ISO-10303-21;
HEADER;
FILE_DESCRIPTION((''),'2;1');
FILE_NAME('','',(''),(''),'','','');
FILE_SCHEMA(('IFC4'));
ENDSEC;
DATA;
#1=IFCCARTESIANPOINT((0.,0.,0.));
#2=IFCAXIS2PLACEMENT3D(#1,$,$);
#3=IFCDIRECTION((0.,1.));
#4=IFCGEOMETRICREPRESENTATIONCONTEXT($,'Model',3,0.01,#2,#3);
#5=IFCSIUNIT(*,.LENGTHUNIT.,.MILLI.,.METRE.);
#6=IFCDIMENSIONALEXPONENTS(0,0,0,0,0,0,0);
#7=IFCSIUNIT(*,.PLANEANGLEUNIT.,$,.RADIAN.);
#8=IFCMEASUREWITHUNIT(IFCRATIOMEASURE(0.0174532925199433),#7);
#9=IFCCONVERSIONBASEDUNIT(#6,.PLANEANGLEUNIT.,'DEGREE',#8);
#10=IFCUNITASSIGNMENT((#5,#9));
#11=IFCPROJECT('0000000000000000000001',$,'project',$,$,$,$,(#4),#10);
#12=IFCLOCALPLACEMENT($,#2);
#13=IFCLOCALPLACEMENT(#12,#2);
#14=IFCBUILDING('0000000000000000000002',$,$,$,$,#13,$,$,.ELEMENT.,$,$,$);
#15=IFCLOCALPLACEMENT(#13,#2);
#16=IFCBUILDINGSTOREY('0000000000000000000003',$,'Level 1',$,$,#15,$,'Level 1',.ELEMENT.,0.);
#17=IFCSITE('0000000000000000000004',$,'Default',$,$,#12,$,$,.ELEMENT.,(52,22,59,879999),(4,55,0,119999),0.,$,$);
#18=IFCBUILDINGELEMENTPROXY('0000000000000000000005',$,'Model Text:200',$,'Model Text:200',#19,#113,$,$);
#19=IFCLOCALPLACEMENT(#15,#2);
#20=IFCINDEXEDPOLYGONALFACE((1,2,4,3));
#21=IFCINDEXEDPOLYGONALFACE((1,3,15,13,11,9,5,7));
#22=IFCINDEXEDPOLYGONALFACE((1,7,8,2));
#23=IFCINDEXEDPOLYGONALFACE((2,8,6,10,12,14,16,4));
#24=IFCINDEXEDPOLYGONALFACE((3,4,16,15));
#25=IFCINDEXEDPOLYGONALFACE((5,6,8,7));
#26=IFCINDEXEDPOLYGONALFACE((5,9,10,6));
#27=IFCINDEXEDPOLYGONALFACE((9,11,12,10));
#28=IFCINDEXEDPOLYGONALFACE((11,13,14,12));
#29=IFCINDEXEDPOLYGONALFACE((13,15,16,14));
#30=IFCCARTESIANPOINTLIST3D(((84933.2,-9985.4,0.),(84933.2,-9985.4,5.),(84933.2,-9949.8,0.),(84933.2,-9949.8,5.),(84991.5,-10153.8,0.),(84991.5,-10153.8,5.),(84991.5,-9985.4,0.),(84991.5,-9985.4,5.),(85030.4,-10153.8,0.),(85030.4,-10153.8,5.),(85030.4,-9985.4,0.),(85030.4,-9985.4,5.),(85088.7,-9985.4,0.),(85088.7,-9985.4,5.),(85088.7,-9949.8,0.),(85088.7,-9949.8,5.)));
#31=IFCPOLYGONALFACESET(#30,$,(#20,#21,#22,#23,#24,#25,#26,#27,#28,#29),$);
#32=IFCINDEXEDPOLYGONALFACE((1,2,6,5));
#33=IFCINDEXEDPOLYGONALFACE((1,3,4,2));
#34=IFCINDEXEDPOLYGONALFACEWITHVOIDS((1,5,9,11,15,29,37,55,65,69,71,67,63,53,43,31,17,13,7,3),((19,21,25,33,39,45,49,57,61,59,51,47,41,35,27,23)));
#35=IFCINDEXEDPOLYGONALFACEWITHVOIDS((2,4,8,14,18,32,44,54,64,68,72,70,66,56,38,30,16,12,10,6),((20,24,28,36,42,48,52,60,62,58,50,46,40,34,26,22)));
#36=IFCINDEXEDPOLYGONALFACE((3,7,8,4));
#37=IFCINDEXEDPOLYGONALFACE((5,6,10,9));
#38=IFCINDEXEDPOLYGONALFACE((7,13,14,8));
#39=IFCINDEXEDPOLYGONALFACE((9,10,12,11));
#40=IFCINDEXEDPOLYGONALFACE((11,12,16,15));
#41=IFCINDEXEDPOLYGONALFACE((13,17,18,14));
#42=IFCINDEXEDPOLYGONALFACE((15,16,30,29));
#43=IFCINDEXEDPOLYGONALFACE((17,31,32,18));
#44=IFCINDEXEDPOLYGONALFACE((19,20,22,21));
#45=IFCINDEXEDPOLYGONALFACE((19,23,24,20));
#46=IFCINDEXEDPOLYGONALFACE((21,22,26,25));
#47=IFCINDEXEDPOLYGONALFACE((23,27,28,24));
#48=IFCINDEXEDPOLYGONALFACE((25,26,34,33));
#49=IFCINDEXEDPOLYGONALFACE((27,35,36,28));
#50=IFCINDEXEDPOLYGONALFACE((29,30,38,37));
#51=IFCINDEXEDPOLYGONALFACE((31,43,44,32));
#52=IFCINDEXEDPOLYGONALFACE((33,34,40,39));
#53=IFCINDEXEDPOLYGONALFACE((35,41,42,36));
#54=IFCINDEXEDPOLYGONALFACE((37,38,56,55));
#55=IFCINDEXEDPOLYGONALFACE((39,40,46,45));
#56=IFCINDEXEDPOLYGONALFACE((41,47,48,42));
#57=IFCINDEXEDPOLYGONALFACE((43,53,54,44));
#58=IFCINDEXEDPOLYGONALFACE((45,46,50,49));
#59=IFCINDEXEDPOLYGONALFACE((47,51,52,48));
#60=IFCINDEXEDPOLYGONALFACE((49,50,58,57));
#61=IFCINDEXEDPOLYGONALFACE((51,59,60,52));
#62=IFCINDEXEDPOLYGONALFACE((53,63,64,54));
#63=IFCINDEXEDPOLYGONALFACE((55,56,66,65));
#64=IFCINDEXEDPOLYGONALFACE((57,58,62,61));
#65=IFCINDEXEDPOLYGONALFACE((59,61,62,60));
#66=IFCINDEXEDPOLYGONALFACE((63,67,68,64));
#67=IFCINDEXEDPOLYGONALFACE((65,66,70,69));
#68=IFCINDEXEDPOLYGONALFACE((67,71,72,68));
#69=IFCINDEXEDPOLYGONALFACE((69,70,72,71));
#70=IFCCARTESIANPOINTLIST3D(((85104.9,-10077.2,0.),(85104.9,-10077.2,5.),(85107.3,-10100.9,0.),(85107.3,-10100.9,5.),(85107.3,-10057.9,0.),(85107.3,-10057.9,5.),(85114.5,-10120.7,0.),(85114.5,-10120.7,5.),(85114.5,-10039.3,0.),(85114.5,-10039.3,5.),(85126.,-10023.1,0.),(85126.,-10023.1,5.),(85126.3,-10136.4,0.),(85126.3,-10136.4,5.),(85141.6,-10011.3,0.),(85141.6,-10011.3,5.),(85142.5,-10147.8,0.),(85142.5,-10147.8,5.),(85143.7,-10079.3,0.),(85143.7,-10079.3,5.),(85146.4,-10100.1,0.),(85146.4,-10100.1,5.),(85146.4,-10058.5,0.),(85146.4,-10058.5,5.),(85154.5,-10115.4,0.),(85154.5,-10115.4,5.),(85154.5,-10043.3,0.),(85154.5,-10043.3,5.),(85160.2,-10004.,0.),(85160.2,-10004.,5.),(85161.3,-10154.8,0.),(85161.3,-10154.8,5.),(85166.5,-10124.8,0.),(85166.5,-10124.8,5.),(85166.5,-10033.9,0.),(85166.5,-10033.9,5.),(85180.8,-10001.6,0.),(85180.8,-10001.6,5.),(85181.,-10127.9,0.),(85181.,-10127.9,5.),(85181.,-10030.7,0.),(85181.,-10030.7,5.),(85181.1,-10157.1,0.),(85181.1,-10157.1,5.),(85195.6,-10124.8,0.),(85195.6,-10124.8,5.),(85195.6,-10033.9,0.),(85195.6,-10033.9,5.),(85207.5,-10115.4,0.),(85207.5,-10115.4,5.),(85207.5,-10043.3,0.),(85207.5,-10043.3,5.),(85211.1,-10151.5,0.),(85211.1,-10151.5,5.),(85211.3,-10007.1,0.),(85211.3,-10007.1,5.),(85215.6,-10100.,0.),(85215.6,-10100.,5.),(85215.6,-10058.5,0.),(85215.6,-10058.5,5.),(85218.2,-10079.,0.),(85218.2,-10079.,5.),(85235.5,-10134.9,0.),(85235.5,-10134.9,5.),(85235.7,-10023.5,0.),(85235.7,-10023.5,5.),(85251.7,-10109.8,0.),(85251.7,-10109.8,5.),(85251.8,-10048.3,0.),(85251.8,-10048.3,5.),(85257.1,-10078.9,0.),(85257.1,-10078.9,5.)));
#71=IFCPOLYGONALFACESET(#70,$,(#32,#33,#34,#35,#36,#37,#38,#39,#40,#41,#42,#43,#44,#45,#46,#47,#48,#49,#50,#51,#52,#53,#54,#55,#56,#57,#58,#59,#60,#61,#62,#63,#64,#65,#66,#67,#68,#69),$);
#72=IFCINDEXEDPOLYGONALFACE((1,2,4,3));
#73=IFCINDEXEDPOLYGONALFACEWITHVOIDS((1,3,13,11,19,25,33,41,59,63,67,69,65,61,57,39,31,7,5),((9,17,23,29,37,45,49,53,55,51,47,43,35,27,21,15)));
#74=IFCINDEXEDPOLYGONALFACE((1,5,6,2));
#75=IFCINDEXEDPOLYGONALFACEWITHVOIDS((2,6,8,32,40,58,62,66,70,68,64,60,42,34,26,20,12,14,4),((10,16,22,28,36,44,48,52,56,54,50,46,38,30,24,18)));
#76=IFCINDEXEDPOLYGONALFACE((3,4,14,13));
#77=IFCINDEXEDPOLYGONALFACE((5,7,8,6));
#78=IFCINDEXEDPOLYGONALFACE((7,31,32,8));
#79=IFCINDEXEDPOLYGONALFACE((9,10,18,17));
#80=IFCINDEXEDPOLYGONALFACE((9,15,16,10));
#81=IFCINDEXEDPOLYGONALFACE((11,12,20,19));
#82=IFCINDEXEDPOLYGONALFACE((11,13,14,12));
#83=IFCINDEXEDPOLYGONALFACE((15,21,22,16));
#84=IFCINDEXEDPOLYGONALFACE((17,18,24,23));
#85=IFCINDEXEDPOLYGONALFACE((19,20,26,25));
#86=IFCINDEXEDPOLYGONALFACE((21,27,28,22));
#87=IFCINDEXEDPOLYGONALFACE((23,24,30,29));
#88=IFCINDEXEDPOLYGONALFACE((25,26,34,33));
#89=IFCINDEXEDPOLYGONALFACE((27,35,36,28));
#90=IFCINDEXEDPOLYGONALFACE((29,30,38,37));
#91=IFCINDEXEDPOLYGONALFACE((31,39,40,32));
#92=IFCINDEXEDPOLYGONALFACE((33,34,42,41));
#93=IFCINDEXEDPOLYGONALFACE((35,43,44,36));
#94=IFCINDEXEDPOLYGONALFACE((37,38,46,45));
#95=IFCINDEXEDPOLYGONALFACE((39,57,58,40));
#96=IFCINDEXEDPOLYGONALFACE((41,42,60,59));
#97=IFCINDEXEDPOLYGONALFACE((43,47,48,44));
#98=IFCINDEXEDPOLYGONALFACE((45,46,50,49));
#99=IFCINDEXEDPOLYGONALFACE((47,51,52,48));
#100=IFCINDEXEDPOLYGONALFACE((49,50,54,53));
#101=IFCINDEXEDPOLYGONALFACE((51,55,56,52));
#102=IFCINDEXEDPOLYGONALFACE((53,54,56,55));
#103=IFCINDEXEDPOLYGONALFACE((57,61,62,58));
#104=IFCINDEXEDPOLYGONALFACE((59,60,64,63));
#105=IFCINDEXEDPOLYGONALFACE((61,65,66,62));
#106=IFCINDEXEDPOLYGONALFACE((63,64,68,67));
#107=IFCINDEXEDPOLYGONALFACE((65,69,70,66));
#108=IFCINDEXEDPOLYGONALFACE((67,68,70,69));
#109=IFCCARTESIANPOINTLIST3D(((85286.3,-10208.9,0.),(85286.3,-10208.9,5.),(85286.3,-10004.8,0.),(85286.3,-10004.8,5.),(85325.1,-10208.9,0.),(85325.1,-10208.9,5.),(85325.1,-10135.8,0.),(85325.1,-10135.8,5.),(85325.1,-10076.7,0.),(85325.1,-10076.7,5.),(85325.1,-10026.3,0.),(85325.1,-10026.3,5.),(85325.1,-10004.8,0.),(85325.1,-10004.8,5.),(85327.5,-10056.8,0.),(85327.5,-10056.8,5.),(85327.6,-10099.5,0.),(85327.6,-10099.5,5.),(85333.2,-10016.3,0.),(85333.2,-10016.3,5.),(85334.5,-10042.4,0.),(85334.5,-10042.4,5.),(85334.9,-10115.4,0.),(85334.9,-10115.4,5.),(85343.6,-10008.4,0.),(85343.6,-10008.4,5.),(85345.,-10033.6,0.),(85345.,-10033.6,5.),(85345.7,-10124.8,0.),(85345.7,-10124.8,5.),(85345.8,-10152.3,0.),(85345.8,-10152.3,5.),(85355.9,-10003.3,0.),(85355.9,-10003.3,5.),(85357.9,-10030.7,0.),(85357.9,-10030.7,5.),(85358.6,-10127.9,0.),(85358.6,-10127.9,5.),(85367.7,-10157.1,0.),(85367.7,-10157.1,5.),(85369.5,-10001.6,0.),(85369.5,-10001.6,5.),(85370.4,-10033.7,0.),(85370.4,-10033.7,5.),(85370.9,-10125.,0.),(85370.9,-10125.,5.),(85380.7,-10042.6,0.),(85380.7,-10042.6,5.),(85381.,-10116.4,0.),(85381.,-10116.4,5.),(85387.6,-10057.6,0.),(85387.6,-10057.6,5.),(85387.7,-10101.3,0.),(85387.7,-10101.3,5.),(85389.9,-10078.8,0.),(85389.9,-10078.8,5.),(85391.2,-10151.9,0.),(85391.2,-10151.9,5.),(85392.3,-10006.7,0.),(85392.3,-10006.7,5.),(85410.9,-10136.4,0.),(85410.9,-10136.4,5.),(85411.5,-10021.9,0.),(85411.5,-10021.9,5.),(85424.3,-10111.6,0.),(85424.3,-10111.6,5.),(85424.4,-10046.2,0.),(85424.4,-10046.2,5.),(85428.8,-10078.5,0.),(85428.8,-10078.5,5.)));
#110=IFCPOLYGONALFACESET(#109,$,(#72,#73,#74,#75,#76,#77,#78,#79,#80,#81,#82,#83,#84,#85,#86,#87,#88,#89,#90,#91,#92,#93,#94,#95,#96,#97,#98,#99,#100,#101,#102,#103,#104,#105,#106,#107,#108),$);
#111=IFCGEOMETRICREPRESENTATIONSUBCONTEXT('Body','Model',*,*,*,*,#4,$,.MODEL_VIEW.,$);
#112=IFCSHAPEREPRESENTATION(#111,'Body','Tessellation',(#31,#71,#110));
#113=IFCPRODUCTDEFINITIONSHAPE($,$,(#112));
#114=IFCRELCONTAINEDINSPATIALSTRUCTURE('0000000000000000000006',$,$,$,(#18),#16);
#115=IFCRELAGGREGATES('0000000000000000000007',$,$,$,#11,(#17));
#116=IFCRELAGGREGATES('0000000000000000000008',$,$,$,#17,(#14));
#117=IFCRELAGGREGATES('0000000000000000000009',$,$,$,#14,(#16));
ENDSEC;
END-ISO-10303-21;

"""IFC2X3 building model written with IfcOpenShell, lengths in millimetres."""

from ifc_helpers import new_model, entity, si_unit, converted_unit, direction, frame, origin, place, context, subcontext, project, spatial, polyline, outline, extrude, element, save


model = new_model("IFC2X3")

# Units and contexts
model_context = context("Model", 3, precision=0.01, world=origin(), true_north=direction((0.0, 1.0)))
body_context = subcontext(model_context, "Body", "Model", "MODEL_VIEW")
ifc_project = project(units=[si_unit("LENGTHUNIT", "METRE", prefix="MILLI"), converted_unit("PLANEANGLEUNIT", "DEGREE", entity("IfcRatioMeasure", 0.0174532925199433), si_unit("PLANEANGLEUNIT", "RADIAN"), dimensions=[0, 0, 0, 0, 0, 0, 0])], contexts=[model_context])

# Site, building, storey
site_placement = place(None, origin())
site = spatial("IfcSite", under=ifc_project, at=site_placement, Name="Default", CompositionType="ELEMENT", RefLatitude=(52, 22, 59, 879999), RefLongitude=(4, 55, 0, 119999), RefElevation=0.0)
building_placement = place(site_placement, origin())
building = spatial("IfcBuilding", under=site, at=building_placement, CompositionType="ELEMENT")
storey_placement = place(building_placement, origin())
storey = spatial("IfcBuildingStorey", under=building, at=storey_placement, Name="Level 1", LongName="Level 1", CompositionType="ELEMENT", Elevation=0.0)

# Building element proxy
proxy_1_placement = place(building_placement, origin())
element("IfcBuildingElementProxy", 1, at=proxy_1_placement, inside=storey, Name="Model Text:200", ObjectType="Model Text:200", context=body_context, shape_type="SweptSolid", body=[
    extrude(outline(polyline([(-19.4, -135.2), (19.4, -135.2), (19.4, 33.2), (77.7, 33.2), (77.7, 68.8), (-77.7, 68.8), (-77.7, 33.2), (-19.4, 33.2), (-19.4, -135.2)])), frame((85010.9, -10018.6, 0.0)), (0.0, 0.0, 1.0), 5.0),
    extrude(outline(polyline([(-8.8, -65.7), (15.1, -65.7), (35.5, -60.5), (52.3, -50.4), (65.3, -35.4), (74.1, -17.3), (78.4, 2.1), (75.9, 32.5), (61.8, 58.5), (38.4, 77.1), (8.3, 85.6), (-22.7, 83.3), (-49.0, 69.9), (-67.8, 47.3), (-76.3, 17.5), (-76.0, -3.3), (-70.7, -22.5), (-60.5, -39.2), (-45.5, -52.3), (-27.7, -61.4), (-8.8, -65.7)]), holes=[polyline([(-2.7, -27.2), (-23.1, -22.5), (-37.5, -12.9), (-45.7, 0.0), (-47.3, 14.8), (-42.7, 28.9), (-32.2, 39.9), (-16.3, 46.3), (4.5, 46.9), (25.1, 42.1), (39.6, 32.6), (47.7, 19.7), (49.4, 5.0), (44.8, -9.2), (34.2, -20.2), (18.2, -26.7), (-2.7, -27.2)])]), frame((85171.1, -10079.3, 0.0), z_axis=(0.0, 0.0, 1.0), x_axis=(0.100608, -0.994926, 0.0)), (0.0, 0.0, 1.0), 5.0),
    extrude(outline(polyline([(-73.1, -75.4), (130.9, -75.4), (130.9, -36.6), (57.8, -36.6), (74.3, -15.9), (79.1, 6.0), (73.9, 29.5), (58.4, 49.2), (33.6, 62.6), (0.5, 67.1), (-31.8, 62.8), (-56.1, 49.8), (-71.3, 30.7), (-76.4, 7.8), (-74.7, -5.8), (-69.6, -18.1), (-61.7, -28.5), (-51.7, -36.6), (-73.1, -36.6), (-73.1, -75.4)]), holes=[polyline([(-1.2, -36.6), (-21.2, -34.2), (-35.6, -27.2), (-44.3, -16.7), (-47.2, -3.8), (-44.3, 8.7), (-35.4, 19.0), (-20.4, 25.9), (0.8, 28.2), (23.3, 26.0), (38.5, 19.3), (47.1, 9.2), (49.9, -3.1), (46.8, -16.0), (37.4, -26.8), (21.5, -34.1), (-1.2, -36.6)])]), frame((85361.7, -10078.0, 0.0), z_axis=(0.0, 0.0, 1.0), x_axis=(0.0, -1.0, 0.0)), (0.0, 0.0, 1.0), 5.0),
])

save(model, "model.ifc")
